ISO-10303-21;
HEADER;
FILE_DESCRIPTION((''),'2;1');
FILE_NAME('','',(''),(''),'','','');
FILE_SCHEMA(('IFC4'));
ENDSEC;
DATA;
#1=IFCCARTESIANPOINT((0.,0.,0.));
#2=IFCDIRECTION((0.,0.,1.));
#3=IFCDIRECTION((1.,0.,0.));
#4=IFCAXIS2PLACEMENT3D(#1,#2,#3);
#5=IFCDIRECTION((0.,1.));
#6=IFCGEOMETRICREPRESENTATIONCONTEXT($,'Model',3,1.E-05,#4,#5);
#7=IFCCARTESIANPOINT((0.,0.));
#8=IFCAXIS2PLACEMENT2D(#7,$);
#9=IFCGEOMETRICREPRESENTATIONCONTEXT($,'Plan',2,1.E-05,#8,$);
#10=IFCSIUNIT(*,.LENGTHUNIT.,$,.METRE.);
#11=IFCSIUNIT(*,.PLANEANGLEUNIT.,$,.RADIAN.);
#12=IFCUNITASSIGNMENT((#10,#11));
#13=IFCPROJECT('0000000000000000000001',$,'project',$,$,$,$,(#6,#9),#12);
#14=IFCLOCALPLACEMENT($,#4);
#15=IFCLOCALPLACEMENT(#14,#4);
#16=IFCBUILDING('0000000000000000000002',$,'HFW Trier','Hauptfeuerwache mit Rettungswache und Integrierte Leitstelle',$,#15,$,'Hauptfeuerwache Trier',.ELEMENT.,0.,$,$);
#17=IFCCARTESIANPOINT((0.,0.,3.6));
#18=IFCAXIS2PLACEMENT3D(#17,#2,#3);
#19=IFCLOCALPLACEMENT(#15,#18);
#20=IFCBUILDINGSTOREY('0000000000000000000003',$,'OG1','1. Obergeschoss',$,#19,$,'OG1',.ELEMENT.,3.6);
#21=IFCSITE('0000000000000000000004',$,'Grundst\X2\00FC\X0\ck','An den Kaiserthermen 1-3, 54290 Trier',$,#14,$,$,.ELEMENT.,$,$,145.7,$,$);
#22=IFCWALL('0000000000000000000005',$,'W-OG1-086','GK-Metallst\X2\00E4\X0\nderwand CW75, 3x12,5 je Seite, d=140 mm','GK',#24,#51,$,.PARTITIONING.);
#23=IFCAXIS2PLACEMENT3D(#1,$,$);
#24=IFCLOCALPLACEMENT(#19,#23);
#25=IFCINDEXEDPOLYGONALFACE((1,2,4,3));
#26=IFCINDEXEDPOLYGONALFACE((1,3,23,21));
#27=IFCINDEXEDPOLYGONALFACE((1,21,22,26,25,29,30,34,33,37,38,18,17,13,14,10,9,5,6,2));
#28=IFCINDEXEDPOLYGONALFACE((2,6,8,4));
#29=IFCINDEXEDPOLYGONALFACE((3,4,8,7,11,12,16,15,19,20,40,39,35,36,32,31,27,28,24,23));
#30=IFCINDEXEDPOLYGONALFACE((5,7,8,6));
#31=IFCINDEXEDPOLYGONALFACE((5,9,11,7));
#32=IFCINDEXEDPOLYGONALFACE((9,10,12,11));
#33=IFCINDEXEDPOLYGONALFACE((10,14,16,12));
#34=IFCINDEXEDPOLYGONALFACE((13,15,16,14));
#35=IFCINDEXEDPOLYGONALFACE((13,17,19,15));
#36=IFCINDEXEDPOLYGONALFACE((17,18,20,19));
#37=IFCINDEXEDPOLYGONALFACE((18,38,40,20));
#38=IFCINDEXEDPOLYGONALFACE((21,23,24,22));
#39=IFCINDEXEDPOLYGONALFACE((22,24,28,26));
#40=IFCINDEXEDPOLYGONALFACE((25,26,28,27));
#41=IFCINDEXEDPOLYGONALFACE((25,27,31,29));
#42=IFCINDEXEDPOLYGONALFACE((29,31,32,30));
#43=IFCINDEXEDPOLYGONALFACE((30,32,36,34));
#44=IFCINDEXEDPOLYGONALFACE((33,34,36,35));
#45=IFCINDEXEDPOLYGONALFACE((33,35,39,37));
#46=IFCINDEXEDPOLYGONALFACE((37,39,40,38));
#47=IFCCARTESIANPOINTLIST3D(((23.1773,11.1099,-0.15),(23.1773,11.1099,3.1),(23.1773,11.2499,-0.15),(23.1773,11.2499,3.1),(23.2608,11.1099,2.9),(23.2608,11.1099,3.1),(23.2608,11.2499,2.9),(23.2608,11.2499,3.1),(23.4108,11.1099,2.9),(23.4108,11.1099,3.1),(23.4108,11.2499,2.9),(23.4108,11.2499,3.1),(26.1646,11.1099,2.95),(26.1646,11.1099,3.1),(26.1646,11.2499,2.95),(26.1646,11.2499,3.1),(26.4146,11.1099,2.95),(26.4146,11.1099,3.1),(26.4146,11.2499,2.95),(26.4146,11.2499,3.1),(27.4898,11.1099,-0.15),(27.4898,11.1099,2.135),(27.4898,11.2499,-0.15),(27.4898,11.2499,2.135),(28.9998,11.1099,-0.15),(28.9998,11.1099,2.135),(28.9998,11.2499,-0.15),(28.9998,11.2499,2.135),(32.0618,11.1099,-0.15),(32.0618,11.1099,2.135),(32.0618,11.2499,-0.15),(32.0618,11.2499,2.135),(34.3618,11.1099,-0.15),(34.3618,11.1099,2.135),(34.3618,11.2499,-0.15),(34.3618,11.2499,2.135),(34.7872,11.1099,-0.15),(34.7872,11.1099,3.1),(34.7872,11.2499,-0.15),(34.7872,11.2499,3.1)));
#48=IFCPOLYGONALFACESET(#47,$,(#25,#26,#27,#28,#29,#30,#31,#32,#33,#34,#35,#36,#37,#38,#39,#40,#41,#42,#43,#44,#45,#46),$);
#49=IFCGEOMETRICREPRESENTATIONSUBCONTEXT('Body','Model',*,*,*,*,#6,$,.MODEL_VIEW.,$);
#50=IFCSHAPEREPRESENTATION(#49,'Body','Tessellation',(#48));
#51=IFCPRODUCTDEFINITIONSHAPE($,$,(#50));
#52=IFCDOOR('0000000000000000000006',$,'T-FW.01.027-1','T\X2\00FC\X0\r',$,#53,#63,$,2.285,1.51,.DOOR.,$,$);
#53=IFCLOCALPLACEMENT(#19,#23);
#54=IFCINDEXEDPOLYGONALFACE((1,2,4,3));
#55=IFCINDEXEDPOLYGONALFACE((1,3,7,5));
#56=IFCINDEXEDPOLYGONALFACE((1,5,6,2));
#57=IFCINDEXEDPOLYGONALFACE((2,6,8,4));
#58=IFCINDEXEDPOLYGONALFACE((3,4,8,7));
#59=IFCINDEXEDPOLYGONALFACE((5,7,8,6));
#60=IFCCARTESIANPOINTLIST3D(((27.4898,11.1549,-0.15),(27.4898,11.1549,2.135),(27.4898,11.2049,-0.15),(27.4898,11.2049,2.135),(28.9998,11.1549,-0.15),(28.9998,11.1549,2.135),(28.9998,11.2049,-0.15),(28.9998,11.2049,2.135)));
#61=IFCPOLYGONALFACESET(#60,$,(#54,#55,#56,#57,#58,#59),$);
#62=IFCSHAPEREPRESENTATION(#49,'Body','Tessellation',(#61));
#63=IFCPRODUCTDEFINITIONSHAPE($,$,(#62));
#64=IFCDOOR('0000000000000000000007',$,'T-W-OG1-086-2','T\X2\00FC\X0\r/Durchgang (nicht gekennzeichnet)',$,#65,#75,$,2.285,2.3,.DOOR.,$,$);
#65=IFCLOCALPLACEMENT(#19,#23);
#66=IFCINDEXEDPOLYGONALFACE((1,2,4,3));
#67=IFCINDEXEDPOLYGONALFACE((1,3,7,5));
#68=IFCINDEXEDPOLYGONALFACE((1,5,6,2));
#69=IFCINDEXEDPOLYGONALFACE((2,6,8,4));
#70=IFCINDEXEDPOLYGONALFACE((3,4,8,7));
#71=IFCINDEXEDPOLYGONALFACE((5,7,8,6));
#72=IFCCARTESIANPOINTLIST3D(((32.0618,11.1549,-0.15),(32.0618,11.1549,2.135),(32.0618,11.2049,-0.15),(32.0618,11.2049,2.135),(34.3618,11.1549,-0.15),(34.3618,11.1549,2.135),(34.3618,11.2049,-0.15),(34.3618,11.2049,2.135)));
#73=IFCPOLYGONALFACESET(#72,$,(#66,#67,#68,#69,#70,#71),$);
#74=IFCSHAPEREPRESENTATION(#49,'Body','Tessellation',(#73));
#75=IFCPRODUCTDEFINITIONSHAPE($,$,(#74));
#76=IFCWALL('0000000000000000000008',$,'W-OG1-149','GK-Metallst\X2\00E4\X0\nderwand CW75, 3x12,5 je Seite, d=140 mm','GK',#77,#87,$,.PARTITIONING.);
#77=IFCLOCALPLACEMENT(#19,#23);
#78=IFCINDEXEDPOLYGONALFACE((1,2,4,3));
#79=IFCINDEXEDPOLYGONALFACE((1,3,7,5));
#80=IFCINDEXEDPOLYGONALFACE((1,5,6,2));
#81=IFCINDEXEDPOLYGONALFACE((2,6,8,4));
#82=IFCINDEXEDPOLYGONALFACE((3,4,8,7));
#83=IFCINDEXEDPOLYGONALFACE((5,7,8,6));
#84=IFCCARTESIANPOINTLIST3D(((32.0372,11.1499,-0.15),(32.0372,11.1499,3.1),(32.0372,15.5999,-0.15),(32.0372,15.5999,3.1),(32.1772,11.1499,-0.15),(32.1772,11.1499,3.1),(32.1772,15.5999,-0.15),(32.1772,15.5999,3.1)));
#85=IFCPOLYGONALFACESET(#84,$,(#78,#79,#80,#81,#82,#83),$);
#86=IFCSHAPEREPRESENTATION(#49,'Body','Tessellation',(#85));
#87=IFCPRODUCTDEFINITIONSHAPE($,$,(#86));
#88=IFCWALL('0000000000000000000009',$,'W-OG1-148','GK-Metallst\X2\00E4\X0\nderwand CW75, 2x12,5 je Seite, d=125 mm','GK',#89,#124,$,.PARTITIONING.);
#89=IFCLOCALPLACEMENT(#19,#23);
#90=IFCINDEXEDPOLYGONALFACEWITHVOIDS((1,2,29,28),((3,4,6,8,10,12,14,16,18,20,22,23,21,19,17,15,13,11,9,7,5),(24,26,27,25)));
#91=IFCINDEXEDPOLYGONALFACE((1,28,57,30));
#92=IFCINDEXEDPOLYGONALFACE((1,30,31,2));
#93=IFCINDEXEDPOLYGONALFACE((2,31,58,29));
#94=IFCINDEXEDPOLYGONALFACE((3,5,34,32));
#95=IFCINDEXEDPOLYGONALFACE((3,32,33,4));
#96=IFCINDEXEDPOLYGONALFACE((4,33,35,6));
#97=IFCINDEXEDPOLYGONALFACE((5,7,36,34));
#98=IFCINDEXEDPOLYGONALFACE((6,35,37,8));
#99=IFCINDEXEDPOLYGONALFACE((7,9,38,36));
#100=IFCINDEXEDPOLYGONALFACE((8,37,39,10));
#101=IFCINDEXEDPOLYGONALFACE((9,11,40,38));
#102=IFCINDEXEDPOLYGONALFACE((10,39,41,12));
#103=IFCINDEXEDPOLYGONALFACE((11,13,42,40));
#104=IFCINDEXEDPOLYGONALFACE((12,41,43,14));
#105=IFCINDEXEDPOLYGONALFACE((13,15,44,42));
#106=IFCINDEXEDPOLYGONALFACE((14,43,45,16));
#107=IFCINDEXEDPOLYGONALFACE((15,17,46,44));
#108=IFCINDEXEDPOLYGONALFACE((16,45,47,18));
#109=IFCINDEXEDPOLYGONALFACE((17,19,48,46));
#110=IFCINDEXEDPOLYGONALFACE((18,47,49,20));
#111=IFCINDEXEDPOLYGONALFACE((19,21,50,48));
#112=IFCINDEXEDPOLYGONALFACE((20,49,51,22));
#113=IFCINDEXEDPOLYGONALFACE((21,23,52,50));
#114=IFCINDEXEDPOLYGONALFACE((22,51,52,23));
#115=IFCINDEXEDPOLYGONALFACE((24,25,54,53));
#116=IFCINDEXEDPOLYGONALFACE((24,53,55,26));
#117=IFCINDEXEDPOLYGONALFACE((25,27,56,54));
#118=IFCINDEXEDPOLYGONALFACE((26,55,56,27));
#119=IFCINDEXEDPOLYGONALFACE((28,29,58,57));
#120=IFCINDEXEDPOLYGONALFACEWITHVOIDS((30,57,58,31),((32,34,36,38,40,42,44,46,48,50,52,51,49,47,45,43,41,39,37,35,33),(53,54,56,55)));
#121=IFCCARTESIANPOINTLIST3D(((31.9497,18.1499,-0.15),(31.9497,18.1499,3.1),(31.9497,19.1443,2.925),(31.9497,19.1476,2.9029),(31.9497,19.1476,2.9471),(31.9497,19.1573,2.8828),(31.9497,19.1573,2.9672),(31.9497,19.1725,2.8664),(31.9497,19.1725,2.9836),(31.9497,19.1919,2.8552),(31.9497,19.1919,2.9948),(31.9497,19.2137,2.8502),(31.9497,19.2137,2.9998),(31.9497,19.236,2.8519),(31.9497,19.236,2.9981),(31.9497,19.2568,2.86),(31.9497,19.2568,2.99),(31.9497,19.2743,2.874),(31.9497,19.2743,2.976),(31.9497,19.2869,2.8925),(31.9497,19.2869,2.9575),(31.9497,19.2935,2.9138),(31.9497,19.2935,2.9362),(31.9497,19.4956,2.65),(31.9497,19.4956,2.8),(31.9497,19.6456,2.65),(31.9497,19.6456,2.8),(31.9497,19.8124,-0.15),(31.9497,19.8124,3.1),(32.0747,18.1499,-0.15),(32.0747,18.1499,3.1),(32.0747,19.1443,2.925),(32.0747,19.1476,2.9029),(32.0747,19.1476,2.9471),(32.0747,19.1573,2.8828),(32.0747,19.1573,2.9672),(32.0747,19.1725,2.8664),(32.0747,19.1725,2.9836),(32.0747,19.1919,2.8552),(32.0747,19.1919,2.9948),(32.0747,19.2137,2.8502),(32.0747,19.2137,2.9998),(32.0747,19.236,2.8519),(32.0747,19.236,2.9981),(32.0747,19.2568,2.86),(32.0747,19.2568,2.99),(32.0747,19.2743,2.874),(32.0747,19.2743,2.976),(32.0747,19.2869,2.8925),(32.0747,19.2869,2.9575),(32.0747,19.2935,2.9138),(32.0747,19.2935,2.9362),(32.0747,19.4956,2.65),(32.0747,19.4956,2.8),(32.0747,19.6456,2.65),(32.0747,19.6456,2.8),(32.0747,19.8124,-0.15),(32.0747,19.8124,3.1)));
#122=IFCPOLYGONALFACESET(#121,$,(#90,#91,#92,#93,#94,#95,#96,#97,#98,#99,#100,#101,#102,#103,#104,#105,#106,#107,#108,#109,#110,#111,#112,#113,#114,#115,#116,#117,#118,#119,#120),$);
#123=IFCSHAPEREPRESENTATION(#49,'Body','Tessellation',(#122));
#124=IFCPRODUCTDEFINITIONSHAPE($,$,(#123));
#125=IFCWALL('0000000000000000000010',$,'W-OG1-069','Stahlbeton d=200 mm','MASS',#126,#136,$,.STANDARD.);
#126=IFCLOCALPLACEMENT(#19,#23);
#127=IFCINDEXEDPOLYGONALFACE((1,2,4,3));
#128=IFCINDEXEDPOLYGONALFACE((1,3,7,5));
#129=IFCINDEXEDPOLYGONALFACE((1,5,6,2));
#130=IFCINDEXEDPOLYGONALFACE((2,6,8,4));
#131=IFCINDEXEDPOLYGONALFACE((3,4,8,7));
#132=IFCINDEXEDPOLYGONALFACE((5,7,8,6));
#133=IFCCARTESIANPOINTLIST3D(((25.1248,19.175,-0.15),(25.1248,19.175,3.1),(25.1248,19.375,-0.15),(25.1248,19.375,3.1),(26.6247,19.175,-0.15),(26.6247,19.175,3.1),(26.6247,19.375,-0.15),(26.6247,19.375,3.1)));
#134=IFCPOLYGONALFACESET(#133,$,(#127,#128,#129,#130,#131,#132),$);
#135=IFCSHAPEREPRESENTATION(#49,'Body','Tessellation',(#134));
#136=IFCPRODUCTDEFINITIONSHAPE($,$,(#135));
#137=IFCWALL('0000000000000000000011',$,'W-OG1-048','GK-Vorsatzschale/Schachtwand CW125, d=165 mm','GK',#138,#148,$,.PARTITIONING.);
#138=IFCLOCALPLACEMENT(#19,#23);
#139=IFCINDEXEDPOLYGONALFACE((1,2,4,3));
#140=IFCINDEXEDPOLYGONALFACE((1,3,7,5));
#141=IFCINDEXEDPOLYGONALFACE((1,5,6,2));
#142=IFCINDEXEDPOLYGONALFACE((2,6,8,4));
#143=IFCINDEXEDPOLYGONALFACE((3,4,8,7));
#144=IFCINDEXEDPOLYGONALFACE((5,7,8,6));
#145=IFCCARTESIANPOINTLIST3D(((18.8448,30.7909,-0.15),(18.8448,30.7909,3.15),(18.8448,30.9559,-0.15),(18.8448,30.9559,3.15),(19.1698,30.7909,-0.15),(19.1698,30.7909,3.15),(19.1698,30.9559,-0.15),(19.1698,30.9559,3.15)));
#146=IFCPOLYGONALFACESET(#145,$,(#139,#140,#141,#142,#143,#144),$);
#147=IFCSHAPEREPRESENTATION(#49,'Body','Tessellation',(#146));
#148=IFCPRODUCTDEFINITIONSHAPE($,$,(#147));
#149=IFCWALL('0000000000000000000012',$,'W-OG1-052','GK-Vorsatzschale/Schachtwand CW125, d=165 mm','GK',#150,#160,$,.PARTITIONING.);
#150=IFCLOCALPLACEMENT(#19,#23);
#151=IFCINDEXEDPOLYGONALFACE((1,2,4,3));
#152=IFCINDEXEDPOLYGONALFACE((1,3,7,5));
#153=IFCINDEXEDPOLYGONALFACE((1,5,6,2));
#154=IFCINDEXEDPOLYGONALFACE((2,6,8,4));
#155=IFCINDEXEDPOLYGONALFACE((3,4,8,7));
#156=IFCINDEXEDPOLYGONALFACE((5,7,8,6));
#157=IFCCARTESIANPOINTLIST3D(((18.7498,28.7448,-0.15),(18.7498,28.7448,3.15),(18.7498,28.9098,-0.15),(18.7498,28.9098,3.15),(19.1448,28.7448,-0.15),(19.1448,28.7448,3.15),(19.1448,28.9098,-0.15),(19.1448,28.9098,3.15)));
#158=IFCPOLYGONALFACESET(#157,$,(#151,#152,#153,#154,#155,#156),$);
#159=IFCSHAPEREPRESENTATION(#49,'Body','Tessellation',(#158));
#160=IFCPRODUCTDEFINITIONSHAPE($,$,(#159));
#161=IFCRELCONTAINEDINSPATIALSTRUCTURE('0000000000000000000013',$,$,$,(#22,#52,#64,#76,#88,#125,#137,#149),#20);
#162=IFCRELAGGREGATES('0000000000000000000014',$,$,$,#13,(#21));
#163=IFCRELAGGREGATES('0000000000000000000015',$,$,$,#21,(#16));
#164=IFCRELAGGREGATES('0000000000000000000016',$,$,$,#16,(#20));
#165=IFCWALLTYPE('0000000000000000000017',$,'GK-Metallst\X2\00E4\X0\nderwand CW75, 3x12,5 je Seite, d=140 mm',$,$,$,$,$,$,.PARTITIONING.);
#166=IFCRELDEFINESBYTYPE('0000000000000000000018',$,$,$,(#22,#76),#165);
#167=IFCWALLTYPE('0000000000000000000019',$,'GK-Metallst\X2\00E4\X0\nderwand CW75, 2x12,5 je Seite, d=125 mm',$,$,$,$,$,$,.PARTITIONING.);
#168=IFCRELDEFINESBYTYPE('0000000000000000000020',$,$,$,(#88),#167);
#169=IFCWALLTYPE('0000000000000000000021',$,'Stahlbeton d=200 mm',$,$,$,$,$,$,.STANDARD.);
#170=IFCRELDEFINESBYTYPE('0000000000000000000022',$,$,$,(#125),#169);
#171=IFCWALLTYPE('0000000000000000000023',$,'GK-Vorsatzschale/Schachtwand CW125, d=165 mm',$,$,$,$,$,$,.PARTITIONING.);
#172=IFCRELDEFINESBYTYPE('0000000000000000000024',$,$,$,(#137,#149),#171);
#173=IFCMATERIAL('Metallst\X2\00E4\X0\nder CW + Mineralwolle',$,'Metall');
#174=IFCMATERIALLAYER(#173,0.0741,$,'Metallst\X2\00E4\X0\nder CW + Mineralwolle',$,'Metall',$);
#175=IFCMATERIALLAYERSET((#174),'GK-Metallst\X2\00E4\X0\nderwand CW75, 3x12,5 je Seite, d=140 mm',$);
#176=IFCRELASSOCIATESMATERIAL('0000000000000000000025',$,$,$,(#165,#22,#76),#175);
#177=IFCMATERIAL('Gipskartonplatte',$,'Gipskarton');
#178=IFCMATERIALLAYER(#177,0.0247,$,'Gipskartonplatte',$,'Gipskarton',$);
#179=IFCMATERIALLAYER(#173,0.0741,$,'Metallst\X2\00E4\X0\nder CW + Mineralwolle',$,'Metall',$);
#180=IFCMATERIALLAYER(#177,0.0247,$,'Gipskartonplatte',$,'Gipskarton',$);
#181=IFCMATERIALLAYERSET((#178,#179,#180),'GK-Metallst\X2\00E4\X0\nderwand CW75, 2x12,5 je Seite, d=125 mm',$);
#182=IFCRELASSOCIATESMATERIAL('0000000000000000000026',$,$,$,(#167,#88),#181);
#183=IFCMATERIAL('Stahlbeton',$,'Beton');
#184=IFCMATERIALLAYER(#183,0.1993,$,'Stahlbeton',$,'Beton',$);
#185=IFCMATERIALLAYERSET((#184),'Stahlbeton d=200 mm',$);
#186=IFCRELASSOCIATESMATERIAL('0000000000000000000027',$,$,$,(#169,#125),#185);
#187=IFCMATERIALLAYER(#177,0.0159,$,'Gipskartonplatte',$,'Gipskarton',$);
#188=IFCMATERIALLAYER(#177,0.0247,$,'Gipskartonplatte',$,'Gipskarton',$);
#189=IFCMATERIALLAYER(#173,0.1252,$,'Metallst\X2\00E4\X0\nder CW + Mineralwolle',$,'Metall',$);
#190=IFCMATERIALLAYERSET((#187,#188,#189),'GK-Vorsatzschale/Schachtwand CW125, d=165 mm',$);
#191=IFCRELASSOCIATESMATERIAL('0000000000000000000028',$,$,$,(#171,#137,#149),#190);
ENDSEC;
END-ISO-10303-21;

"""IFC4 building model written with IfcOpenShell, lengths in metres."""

from ifc_helpers import new_model, si_unit, direction, frame, frame_2d, origin_with_axes, origin_2d, place, context, subcontext, project, spatial, rectangle, circle, extrude, material, layer, layer_set, layer_usage, type_object, element, fill, save


model = new_model("IFC4")

# Units and contexts
model_context = context("Model", 3, precision=1e-05, world=origin_with_axes(), true_north=direction((0.0, 1.0)))
plan_context = context("Plan", 2, precision=1e-05, world=origin_2d())
body_context = subcontext(model_context, "Body", "Model", "MODEL_VIEW")
ifc_project = project(units=[si_unit("LENGTHUNIT", "METRE"), si_unit("PLANEANGLEUNIT", "RADIAN")], contexts=[model_context, plan_context])

# Site, building, storey
site_placement = place(None, origin_with_axes())
site = spatial("IfcSite", under=ifc_project, at=site_placement, Name="Grundstück", Description="An den Kaiserthermen 1-3, 54290 Trier", CompositionType="ELEMENT", RefElevation=145.7)
building_placement = place(site_placement, origin_with_axes())
building = spatial("IfcBuilding", under=site, at=building_placement, Name="HFW Trier", Description="Hauptfeuerwache mit Rettungswache und Integrierte Leitstelle", LongName="Hauptfeuerwache Trier", CompositionType="ELEMENT", ElevationOfRefHeight=0.0)
storey_placement = place(building_placement, frame((0.0, 0.0, 3.6), z_axis=(0.0, 0.0, 1.0), x_axis=(1.0, 0.0, 0.0)))
storey = spatial("IfcBuildingStorey", under=building, at=storey_placement, Name="OG1", Description="1. Obergeschoss", LongName="OG1", CompositionType="ELEMENT", Elevation=3.6)

# Shared definitions
ifc_material_1 = material(Name="Stahlbeton", Category="Beton")

# Wall, openings, doors
ifc_material_2 = material(Name="Metallständer CW + Mineralwolle", Category="Metall")
ifc_layer_1 = layer(ifc_material_2, 0.0741, Name="Metallständer CW + Mineralwolle", Category="Metall")
ifc_layer_set_1 = layer_set([ifc_layer_1], Name="GK-Metallständerwand CW75, 3x12,5 je Seite, d=140 mm")
ifc_layer_usage_1 = layer_usage(ifc_layer_set_1, "AXIS2", "POSITIVE", -0.07)
wall_type_1 = type_object("IfcWallType", Name="GK-Metallständerwand CW75, 3x12,5 je Seite, d=140 mm", PredefinedType="PARTITIONING", material=ifc_layer_set_1)
wall_1_placement = place(storey_placement, frame((23.1773, 11.1799, -0.15), z_axis=(0.0, 0.0, 1.0), x_axis=(1.0, 0.0, 0.0)))
wall_1 = element("IfcWall", 1, at=wall_1_placement, inside=storey, type_object=wall_type_1, material=ifc_layer_usage_1, Name="W-OG1-086", Description="GK-Metallständerwand CW75, 3x12,5 je Seite, d=140 mm", ObjectType="GK", PredefinedType="PARTITIONING", context=body_context, shape_type="SweptSolid", body=[
    extrude(rectangle(XDim=11.6099, YDim=0.14, at=frame_2d((5.8049, 0.0))), origin_with_axes(), (0.0, 0.0, 1.0), 3.25),
])
opening_1_placement = place(wall_1_placement, frame((4.3125, 0.0, 0.0), z_axis=(0.0, 0.0, 1.0), x_axis=(1.0, 0.0, 0.0)))
opening_1 = element("IfcOpeningElement", 2, at=opening_1_placement, cuts=wall_1, PredefinedType="OPENING", context=body_context, shape_type="SweptSolid", body=[
    extrude(rectangle(XDim=1.51, YDim=0.24, at=frame_2d((0.755, 0.0))), origin_with_axes(), (0.0, 0.0, 1.0), 2.285),
])
opening_2_placement = place(wall_1_placement, frame((8.8845, 0.0, 0.0), z_axis=(0.0, 0.0, 1.0), x_axis=(1.0, 0.0, 0.0)))
opening_2 = element("IfcOpeningElement", 3, at=opening_2_placement, cuts=wall_1, PredefinedType="OPENING", context=body_context, shape_type="SweptSolid", body=[
    extrude(rectangle(XDim=2.3, YDim=0.24, at=frame_2d((1.15, 0.0))), origin_with_axes(), (0.0, 0.0, 1.0), 2.285),
])
opening_3_placement = place(wall_1_placement, origin_with_axes())
element("IfcOpeningElement", 4, at=opening_3_placement, cuts=wall_1, ObjectType="Wanddurchbruch", PredefinedType="OPENING", context=body_context, shape_type="SweptSolid", body=[
    extrude(rectangle(XDim=0.15, YDim=0.24, at=frame_2d((0.1585, 0.0))), frame((0.0, 0.0, 3.05), z_axis=(0.0, 0.0, 1.0), x_axis=(1.0, 0.0, 0.0)), (0.0, 0.0, 1.0), 0.2),
])
opening_4_placement = place(wall_1_placement, origin_with_axes())
element("IfcOpeningElement", 5, at=opening_4_placement, cuts=wall_1, ObjectType="Wanddurchbruch", PredefinedType="OPENING", context=body_context, shape_type="SweptSolid", body=[
    extrude(rectangle(XDim=0.25, YDim=0.24, at=frame_2d((3.1123, 0.0))), frame((0.0, 0.0, 3.1), z_axis=(0.0, 0.0, 1.0), x_axis=(1.0, 0.0, 0.0)), (0.0, 0.0, 1.0), 0.15),
])
door_1_placement = place(wall_1_placement, frame((4.3125, 0.0, 0.0), z_axis=(0.0, 0.0, 1.0), x_axis=(1.0, 0.0, 0.0)))
door_1 = element("IfcDoor", 6, at=door_1_placement, inside=storey, Name="T-FW.01.027-1", Description="Tür", OverallHeight=2.285, OverallWidth=1.51, PredefinedType="DOOR", context=body_context, shape_type="SweptSolid", body=[
    extrude(rectangle(XDim=1.51, YDim=0.05, at=frame_2d((0.755, 0.0))), origin_with_axes(), (0.0, 0.0, 1.0), 2.285),
])
fill(opening_1, door_1)
door_2_placement = place(wall_1_placement, frame((8.8845, 0.0, 0.0), z_axis=(0.0, 0.0, 1.0), x_axis=(1.0, 0.0, 0.0)))
door_2 = element("IfcDoor", 7, at=door_2_placement, inside=storey, Name="T-W-OG1-086-2", Description="Tür/Durchgang (nicht gekennzeichnet)", OverallHeight=2.285, OverallWidth=2.3, PredefinedType="DOOR", context=body_context, shape_type="SweptSolid", body=[
    extrude(rectangle(XDim=2.3, YDim=0.05, at=frame_2d((1.15, 0.0))), origin_with_axes(), (0.0, 0.0, 1.0), 2.285),
])
fill(opening_2, door_2)

# Wall
ifc_layer_usage_2 = layer_usage(ifc_layer_set_1, "AXIS2", "POSITIVE", -0.07)
wall_2_placement = place(storey_placement, frame((32.1072, 15.5999, -0.15), z_axis=(0.0, 0.0, 1.0), x_axis=(0.0, -1.0, 0.0)))
element("IfcWall", 8, at=wall_2_placement, inside=storey, type_object=wall_type_1, material=ifc_layer_usage_2, Name="W-OG1-149", Description="GK-Metallständerwand CW75, 3x12,5 je Seite, d=140 mm", ObjectType="GK", PredefinedType="PARTITIONING", context=body_context, shape_type="SweptSolid", body=[
    extrude(rectangle(XDim=4.45, YDim=0.14, at=frame_2d((2.225, 0.0))), origin_with_axes(), (0.0, 0.0, 1.0), 3.25),
])

# Wall, openings
ifc_material_3 = material(Name="Gipskartonplatte", Category="Gipskarton")
ifc_layer_2 = layer(ifc_material_3, 0.0247, Name="Gipskartonplatte", Category="Gipskarton")
ifc_layer_3 = layer(ifc_material_2, 0.0741, Name="Metallständer CW + Mineralwolle", Category="Metall")
ifc_layer_4 = layer(ifc_material_3, 0.0247, Name="Gipskartonplatte", Category="Gipskarton")
ifc_layer_set_2 = layer_set([ifc_layer_2, ifc_layer_3, ifc_layer_4], Name="GK-Metallständerwand CW75, 2x12,5 je Seite, d=125 mm")
ifc_layer_usage_3 = layer_usage(ifc_layer_set_2, "AXIS2", "POSITIVE", -0.0625)
wall_type_2 = type_object("IfcWallType", Name="GK-Metallständerwand CW75, 2x12,5 je Seite, d=125 mm", PredefinedType="PARTITIONING", material=ifc_layer_set_2)
wall_3_placement = place(storey_placement, frame((32.0122, 19.8124, -0.15), z_axis=(0.0, 0.0, 1.0), x_axis=(0.0, -1.0, 0.0)))
wall_3 = element("IfcWall", 9, at=wall_3_placement, inside=storey, type_object=wall_type_2, material=ifc_layer_usage_3, Name="W-OG1-148", Description="GK-Metallständerwand CW75, 2x12,5 je Seite, d=125 mm", ObjectType="GK", PredefinedType="PARTITIONING", context=body_context, shape_type="SweptSolid", body=[
    extrude(rectangle(XDim=1.6625, YDim=0.125, at=frame_2d((0.8313, 0.0))), origin_with_axes(), (0.0, 0.0, 1.0), 3.25),
])
opening_5_placement = place(wall_3_placement, origin_with_axes())
element("IfcOpeningElement", 10, at=opening_5_placement, cuts=wall_3, ObjectType="Wanddurchbruch", PredefinedType="OPENING", context=body_context, shape_type="SweptSolid", body=[
    extrude(circle(Radius=0.075, at=origin_2d()), frame((0.5931, -0.1125, 3.075), z_axis=(0.0, 1.0, 0.0), x_axis=(1.0, 0.0, 0.0)), (0.0, 0.0, 1.0), 0.225),
])
opening_6_placement = place(wall_3_placement, origin_with_axes())
element("IfcOpeningElement", 11, at=opening_6_placement, cuts=wall_3, ObjectType="Wanddurchbruch", PredefinedType="OPENING", context=body_context, shape_type="SweptSolid", body=[
    extrude(rectangle(XDim=0.15, YDim=0.225, at=frame_2d((0.2418, 0.0))), frame((0.0, 0.0, 2.8), z_axis=(0.0, 0.0, 1.0), x_axis=(1.0, 0.0, 0.0)), (0.0, 0.0, 1.0), 0.15),
])

# Walls
ifc_layer_5 = layer(ifc_material_1, 0.1993, Name="Stahlbeton", Category="Beton")
ifc_layer_set_3 = layer_set([ifc_layer_5], Name="Stahlbeton d=200 mm")
ifc_layer_usage_4 = layer_usage(ifc_layer_set_3, "AXIS2", "POSITIVE", -0.1)
wall_type_3 = type_object("IfcWallType", Name="Stahlbeton d=200 mm", PredefinedType="STANDARD", material=ifc_layer_set_3)
wall_4_placement = place(storey_placement, frame((25.1248, 19.275, -0.15), z_axis=(0.0, 0.0, 1.0), x_axis=(1.0, 0.0, 0.0)))
element("IfcWall", 12, at=wall_4_placement, inside=storey, type_object=wall_type_3, material=ifc_layer_usage_4, Name="W-OG1-069", Description="Stahlbeton d=200 mm", ObjectType="MASS", PredefinedType="STANDARD", context=body_context, shape_type="SweptSolid", body=[
    extrude(rectangle(XDim=1.4999, YDim=0.2, at=frame_2d((0.75, 0.0))), origin_with_axes(), (0.0, 0.0, 1.0), 3.25),
])
ifc_layer_6 = layer(ifc_material_3, 0.0159, Name="Gipskartonplatte", Category="Gipskarton")
ifc_layer_7 = layer(ifc_material_3, 0.0247, Name="Gipskartonplatte", Category="Gipskarton")
ifc_layer_8 = layer(ifc_material_2, 0.1252, Name="Metallständer CW + Mineralwolle", Category="Metall")
ifc_layer_set_4 = layer_set([ifc_layer_6, ifc_layer_7, ifc_layer_8], Name="GK-Vorsatzschale/Schachtwand CW125, d=165 mm")
ifc_layer_usage_5 = layer_usage(ifc_layer_set_4, "AXIS2", "POSITIVE", -0.0825)
wall_type_4 = type_object("IfcWallType", Name="GK-Vorsatzschale/Schachtwand CW125, d=165 mm", PredefinedType="PARTITIONING", material=ifc_layer_set_4)
wall_5_placement = place(storey_placement, frame((18.8448, 30.8734, -0.15), z_axis=(0.0, 0.0, 1.0), x_axis=(1.0, 0.0, 0.0)))
element("IfcWall", 13, at=wall_5_placement, inside=storey, type_object=wall_type_4, material=ifc_layer_usage_5, Name="W-OG1-048", Description="GK-Vorsatzschale/Schachtwand CW125, d=165 mm", ObjectType="GK", PredefinedType="PARTITIONING", context=body_context, shape_type="SweptSolid", body=[
    extrude(rectangle(XDim=0.325, YDim=0.165, at=frame_2d((0.1625, 0.0))), origin_with_axes(), (0.0, 0.0, 1.0), 3.3),
])
ifc_layer_usage_6 = layer_usage(ifc_layer_set_4, "AXIS2", "POSITIVE", -0.0825)
wall_6_placement = place(storey_placement, frame((18.7498, 28.8273, -0.15), z_axis=(0.0, 0.0, 1.0), x_axis=(1.0, 0.0, 0.0)))
element("IfcWall", 14, at=wall_6_placement, inside=storey, type_object=wall_type_4, material=ifc_layer_usage_6, Name="W-OG1-052", Description="GK-Vorsatzschale/Schachtwand CW125, d=165 mm", ObjectType="GK", PredefinedType="PARTITIONING", context=body_context, shape_type="SweptSolid", body=[
    extrude(rectangle(XDim=0.395, YDim=0.165, at=frame_2d((0.1975, 0.0))), origin_with_axes(), (0.0, 0.0, 1.0), 3.3),
])

save(model, "model.ifc")
